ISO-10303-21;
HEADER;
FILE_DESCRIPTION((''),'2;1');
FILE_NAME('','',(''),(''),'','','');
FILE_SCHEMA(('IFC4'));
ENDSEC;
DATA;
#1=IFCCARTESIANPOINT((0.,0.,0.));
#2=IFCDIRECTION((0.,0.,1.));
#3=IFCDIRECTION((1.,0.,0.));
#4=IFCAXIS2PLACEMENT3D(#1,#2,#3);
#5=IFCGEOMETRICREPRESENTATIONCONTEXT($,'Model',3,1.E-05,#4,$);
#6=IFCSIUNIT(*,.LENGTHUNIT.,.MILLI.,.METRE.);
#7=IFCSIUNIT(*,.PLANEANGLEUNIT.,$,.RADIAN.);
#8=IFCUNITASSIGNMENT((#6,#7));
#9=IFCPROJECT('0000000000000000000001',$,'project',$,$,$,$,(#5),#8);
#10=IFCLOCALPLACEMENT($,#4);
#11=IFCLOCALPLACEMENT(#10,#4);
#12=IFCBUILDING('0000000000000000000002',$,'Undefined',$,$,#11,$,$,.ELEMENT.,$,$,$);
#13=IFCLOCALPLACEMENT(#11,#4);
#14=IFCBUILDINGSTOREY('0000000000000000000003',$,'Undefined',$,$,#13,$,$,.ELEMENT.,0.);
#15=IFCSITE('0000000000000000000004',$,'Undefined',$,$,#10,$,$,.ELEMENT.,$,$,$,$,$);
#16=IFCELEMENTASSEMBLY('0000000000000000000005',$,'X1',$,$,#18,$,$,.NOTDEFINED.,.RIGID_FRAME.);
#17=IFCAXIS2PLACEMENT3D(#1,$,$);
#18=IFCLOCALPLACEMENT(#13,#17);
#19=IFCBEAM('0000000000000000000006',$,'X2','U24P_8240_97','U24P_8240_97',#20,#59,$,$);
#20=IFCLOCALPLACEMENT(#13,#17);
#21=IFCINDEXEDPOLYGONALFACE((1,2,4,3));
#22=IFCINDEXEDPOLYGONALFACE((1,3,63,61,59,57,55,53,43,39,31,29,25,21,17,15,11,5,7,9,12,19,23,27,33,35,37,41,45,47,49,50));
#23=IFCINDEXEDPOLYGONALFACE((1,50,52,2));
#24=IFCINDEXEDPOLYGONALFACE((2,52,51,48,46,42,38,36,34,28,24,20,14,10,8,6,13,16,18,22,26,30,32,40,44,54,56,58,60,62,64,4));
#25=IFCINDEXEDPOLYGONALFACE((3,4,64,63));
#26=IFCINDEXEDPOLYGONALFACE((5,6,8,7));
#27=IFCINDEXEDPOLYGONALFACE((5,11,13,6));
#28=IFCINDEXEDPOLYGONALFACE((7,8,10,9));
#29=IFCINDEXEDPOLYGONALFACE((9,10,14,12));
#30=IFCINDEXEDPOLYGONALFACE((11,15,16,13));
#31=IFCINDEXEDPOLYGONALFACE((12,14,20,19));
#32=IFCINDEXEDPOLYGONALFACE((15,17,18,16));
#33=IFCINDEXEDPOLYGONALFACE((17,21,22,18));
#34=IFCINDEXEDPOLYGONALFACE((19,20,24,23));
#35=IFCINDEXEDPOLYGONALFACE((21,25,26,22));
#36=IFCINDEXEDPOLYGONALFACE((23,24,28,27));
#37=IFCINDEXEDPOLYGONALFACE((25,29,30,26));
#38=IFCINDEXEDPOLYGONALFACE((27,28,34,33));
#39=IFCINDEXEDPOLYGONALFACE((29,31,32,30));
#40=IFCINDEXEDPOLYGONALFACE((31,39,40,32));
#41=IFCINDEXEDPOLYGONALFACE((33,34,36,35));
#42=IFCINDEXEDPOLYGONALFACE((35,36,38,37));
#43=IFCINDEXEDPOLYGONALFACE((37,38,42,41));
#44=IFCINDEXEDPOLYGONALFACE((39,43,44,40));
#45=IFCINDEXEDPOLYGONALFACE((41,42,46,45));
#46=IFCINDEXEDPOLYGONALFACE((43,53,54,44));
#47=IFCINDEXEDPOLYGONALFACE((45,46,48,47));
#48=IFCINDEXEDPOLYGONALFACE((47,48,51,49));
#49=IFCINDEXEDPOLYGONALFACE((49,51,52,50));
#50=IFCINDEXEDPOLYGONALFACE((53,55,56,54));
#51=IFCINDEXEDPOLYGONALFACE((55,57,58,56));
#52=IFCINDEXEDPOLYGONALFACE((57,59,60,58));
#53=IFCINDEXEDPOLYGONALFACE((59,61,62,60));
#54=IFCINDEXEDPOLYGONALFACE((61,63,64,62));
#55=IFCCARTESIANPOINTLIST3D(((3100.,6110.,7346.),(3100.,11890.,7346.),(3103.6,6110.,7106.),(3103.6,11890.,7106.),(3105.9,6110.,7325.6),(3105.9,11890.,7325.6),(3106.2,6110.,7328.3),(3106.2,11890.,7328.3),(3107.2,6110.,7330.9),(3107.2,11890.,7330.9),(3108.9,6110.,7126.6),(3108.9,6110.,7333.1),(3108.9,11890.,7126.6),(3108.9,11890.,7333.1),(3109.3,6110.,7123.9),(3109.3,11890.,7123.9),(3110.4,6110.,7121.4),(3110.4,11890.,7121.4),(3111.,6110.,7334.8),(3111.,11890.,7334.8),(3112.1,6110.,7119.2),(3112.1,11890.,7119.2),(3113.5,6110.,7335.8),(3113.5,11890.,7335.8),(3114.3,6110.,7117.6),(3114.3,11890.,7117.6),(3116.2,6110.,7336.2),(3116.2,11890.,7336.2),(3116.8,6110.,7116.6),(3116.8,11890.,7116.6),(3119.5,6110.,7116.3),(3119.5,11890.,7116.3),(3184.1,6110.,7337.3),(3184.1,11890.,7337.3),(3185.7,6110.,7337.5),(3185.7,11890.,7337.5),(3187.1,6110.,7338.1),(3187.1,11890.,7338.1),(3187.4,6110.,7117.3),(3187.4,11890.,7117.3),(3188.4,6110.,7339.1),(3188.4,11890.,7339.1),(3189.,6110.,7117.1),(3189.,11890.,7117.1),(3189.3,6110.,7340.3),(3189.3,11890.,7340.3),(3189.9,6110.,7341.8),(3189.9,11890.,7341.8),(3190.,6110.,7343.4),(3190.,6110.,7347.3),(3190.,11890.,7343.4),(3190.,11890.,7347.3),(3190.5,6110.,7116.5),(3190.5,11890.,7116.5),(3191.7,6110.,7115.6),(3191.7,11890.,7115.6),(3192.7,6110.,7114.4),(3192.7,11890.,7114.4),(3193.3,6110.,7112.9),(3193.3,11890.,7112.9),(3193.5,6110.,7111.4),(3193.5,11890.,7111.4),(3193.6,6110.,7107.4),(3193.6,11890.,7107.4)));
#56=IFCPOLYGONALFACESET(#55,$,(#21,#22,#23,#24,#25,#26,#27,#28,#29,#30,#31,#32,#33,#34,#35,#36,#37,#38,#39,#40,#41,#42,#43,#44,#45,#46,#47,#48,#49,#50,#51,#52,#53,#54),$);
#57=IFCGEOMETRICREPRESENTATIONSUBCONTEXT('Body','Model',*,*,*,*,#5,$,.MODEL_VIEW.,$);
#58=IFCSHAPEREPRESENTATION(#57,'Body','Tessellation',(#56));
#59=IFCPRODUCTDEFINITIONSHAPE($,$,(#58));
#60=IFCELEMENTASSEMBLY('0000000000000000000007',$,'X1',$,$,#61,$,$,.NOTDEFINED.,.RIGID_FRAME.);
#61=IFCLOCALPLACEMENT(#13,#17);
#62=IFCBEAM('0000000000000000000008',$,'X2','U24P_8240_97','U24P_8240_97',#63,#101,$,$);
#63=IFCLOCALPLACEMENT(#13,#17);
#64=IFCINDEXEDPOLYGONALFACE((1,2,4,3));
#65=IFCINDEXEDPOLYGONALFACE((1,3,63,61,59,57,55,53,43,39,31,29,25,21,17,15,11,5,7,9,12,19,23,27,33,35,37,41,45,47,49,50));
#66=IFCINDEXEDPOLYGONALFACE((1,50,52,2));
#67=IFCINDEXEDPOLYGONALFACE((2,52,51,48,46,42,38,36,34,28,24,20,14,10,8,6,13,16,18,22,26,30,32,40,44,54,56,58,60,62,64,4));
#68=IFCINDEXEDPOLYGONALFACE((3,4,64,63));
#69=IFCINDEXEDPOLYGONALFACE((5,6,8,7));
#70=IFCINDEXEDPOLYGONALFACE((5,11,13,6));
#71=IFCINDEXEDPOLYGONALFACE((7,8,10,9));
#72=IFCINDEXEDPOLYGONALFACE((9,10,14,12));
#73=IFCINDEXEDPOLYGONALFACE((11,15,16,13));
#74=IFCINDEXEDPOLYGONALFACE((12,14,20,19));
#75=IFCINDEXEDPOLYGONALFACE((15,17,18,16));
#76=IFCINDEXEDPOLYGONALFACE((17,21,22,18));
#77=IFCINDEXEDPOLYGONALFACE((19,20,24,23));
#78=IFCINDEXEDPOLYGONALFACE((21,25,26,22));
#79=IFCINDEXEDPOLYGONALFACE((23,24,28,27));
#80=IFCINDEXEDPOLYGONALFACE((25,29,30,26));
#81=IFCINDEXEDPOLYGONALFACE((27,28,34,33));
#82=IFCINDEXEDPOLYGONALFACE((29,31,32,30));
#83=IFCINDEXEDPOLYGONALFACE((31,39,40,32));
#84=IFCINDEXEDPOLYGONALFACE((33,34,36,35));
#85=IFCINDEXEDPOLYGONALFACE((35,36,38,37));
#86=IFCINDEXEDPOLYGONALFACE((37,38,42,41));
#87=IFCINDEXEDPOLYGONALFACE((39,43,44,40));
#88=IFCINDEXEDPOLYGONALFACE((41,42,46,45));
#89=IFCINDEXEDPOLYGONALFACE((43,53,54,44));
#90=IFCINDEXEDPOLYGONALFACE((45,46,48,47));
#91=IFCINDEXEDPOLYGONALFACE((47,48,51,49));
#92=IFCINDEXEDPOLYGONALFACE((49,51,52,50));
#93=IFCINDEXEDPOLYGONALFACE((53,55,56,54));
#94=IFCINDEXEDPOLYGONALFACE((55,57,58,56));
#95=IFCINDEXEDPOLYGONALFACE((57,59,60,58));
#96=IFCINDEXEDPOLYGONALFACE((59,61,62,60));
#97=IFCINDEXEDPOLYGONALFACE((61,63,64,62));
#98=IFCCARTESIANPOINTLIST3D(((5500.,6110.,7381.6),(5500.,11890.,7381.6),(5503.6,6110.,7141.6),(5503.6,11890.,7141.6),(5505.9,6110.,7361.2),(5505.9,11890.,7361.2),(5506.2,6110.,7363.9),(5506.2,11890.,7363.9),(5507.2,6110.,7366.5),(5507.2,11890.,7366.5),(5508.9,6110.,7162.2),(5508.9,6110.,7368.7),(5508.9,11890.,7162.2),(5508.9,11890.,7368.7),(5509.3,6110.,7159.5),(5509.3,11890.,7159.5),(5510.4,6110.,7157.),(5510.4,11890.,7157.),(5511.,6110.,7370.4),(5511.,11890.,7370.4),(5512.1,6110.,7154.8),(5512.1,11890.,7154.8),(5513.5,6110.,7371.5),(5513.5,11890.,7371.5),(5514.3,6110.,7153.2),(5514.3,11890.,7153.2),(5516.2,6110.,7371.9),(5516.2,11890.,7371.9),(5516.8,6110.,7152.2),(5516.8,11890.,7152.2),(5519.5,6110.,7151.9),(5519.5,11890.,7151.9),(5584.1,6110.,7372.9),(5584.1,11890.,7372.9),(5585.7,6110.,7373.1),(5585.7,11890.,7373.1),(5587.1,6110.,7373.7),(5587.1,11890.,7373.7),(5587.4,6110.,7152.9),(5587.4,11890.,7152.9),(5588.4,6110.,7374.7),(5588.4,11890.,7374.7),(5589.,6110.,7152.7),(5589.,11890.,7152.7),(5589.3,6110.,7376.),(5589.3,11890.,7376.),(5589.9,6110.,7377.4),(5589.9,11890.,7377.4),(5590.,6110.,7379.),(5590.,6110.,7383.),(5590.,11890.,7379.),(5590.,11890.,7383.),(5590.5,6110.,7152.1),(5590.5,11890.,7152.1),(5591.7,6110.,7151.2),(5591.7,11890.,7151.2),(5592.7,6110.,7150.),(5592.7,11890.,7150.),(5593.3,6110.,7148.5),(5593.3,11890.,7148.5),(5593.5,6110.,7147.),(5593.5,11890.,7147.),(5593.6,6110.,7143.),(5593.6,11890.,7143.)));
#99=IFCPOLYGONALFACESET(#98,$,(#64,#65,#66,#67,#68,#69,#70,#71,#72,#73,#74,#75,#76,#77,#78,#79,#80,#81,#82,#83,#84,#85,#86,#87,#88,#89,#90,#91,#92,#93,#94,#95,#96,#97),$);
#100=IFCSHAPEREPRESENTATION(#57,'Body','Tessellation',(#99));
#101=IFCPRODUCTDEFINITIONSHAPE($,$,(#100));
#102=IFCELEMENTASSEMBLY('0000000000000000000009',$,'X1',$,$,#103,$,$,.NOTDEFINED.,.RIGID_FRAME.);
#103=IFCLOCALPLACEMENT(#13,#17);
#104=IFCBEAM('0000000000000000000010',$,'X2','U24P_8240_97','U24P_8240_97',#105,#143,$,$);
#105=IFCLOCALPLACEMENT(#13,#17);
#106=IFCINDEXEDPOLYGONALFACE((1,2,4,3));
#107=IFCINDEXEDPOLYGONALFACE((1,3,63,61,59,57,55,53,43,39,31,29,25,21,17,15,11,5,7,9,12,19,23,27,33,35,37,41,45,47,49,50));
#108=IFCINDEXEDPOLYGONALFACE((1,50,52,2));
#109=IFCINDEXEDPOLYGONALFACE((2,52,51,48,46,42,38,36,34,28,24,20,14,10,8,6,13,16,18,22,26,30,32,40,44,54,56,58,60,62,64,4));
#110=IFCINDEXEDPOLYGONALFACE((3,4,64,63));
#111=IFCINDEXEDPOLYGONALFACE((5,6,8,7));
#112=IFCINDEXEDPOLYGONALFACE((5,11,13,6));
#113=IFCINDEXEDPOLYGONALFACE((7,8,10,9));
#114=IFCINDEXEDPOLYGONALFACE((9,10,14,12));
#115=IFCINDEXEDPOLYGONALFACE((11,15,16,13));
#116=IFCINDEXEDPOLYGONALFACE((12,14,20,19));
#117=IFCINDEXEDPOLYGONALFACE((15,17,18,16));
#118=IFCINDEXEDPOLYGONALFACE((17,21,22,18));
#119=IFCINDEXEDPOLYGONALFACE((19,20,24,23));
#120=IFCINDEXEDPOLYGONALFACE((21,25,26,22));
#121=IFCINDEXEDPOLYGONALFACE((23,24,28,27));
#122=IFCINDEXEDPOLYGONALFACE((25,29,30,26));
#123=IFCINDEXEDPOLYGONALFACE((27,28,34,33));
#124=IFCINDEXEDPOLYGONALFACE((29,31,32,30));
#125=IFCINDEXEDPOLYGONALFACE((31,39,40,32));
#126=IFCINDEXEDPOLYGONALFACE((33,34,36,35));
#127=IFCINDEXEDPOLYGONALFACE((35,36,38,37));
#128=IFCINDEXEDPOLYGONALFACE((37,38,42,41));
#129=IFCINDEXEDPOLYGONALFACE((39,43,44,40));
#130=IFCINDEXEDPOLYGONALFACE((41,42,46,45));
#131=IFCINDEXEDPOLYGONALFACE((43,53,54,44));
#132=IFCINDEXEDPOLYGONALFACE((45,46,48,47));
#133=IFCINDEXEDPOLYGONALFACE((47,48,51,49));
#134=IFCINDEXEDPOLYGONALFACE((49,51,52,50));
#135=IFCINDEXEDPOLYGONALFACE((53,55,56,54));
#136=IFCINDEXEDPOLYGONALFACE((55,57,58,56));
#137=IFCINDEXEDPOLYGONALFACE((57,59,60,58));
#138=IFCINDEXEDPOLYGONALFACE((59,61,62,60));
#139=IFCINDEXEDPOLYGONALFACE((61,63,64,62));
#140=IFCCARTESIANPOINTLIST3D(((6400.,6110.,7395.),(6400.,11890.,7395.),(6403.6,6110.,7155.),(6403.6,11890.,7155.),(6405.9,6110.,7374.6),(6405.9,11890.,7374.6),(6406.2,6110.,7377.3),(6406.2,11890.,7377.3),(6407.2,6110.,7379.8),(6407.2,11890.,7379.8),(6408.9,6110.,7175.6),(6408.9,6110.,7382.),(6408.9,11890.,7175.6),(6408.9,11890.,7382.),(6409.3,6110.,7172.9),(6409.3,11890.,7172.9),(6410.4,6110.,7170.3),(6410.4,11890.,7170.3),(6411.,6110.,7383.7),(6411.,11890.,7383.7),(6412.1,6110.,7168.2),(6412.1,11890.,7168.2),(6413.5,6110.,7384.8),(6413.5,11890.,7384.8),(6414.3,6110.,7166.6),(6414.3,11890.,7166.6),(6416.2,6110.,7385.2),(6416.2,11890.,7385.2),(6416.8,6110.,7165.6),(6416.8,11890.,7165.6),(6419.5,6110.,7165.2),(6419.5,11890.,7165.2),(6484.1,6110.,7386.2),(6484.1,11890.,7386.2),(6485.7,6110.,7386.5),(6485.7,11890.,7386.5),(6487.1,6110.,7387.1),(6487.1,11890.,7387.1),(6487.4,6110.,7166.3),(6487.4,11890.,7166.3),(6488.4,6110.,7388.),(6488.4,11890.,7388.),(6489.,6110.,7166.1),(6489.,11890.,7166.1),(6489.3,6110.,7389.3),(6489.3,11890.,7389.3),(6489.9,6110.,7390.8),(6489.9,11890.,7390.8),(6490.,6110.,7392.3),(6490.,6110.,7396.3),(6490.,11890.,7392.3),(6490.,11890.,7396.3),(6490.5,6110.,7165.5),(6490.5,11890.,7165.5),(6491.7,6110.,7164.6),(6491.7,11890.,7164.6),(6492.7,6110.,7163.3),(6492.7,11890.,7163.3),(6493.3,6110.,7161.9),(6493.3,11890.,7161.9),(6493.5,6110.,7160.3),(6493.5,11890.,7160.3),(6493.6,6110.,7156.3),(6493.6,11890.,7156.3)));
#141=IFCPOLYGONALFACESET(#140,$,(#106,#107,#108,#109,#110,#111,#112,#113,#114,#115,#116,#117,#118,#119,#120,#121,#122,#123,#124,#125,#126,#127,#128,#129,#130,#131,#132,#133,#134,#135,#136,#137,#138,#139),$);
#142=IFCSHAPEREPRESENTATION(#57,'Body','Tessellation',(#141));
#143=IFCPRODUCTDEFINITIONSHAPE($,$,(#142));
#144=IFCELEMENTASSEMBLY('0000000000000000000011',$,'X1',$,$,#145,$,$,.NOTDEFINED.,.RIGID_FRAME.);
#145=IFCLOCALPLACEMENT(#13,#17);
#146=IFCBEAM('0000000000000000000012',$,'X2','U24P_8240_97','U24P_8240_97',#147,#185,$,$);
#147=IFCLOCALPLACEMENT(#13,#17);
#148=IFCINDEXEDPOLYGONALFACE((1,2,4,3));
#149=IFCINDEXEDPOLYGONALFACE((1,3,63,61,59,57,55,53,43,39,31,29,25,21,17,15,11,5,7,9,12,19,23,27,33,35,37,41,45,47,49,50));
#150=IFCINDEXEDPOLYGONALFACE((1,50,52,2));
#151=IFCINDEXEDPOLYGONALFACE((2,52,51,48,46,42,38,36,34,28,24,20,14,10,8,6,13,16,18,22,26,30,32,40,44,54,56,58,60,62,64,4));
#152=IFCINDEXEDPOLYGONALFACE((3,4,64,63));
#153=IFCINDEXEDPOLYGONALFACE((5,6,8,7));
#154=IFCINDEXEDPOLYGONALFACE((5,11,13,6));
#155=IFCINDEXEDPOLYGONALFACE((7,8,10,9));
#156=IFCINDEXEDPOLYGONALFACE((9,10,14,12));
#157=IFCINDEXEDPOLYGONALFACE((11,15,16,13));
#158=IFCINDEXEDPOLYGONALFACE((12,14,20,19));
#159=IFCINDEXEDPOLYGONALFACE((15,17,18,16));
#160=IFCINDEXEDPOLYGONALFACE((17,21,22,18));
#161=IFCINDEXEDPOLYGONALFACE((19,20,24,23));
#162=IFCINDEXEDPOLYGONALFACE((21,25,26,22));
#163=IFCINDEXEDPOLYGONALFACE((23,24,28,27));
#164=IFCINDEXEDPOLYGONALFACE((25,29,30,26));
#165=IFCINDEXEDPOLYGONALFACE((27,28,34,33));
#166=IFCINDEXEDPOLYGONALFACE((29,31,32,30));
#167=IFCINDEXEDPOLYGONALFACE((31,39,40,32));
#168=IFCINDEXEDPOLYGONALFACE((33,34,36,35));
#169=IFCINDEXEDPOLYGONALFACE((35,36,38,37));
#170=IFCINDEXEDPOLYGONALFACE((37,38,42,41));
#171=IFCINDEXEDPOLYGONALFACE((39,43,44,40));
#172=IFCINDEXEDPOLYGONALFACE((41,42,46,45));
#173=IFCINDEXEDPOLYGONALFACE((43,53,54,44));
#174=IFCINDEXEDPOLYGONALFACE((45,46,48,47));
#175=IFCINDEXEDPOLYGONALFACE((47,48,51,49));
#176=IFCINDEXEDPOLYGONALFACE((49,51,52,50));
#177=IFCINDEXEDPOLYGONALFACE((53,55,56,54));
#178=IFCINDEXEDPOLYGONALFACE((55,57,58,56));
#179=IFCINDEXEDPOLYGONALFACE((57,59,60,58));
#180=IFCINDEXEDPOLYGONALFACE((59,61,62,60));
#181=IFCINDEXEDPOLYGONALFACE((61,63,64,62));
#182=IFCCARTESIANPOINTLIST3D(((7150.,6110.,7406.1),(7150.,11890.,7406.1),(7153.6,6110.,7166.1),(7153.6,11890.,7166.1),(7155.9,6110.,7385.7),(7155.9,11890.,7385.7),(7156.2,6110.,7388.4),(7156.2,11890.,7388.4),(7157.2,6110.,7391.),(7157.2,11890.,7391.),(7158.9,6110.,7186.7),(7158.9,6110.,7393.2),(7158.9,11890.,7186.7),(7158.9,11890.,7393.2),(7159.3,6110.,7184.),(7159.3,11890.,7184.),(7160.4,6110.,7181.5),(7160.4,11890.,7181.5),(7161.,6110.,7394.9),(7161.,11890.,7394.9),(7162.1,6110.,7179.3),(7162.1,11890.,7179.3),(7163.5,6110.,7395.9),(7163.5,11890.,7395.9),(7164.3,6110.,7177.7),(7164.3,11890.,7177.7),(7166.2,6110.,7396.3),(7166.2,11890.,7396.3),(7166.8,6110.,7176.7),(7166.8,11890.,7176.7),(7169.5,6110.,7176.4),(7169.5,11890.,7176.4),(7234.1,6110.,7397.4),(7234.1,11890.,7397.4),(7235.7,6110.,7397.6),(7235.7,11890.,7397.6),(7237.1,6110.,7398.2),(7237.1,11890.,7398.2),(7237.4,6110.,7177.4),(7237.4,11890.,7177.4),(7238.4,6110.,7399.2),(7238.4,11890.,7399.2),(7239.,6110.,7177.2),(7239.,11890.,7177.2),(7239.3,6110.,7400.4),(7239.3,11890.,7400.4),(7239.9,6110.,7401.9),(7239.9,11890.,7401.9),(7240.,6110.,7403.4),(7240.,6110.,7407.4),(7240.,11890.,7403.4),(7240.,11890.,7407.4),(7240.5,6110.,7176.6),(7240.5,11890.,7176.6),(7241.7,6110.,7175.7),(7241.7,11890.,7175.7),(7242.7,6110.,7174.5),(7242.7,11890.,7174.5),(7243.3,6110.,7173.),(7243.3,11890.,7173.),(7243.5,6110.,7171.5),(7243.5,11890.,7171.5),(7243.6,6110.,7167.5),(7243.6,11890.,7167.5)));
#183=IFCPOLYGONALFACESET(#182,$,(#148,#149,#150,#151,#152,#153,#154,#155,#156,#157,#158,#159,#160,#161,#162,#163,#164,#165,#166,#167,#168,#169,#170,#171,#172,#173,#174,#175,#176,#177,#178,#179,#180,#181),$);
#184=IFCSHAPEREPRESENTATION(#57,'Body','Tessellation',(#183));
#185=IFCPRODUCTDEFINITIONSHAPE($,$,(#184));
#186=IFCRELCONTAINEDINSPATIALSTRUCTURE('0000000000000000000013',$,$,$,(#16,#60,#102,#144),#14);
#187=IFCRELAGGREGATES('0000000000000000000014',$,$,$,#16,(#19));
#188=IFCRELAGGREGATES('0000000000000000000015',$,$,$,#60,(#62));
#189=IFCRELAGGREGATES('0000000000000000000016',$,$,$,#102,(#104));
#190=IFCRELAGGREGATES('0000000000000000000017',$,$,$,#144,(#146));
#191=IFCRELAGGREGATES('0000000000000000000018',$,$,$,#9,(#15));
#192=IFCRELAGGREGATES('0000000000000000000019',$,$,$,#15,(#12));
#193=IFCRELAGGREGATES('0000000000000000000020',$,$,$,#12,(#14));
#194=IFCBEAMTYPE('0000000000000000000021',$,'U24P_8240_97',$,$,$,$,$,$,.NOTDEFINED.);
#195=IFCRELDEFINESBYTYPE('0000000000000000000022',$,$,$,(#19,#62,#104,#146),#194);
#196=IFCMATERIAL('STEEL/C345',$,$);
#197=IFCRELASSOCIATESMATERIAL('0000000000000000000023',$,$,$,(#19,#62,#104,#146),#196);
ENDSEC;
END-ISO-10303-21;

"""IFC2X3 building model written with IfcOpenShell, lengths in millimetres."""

from ifc_helpers import new_model, si_unit, frame, origin_with_axes, origin_2d_with_axis, place, context, subcontext, project, spatial, u_section, extrude, material, type_object, element, aggregate, save


model = new_model("IFC2X3")

# Units and contexts
model_context = context("Model", 3, precision=1e-05, world=origin_with_axes())
body_context = subcontext(model_context, "Body", "Model", "MODEL_VIEW")
ifc_project = project(units=[si_unit("LENGTHUNIT", "METRE", prefix="MILLI"), si_unit("PLANEANGLEUNIT", "RADIAN")], contexts=[model_context])

# Site, building, storey
site_placement = place(None, origin_with_axes())
site = spatial("IfcSite", under=ifc_project, at=site_placement, Name="Undefined", CompositionType="ELEMENT")
building_placement = place(site_placement, origin_with_axes())
building = spatial("IfcBuilding", under=site, at=building_placement, Name="Undefined", CompositionType="ELEMENT")
storey_placement = place(building_placement, origin_with_axes())
storey = spatial("IfcBuildingStorey", under=building, at=storey_placement, Name="Undefined", CompositionType="ELEMENT", Elevation=0.0)

# Element assemblies, beams
ifc_material_1 = material(Name="STEEL/C345")
beam_type_1 = type_object("IfcBeamType", Name="U24P_8240_97", PredefinedType="NOTDEFINED")
assembly_1_placement = place(storey_placement, origin_with_axes())
assembly_1 = element("IfcElementAssembly", 1, at=assembly_1_placement, inside=storey, Name="X1", AssemblyPlace="NOTDEFINED", PredefinedType="RIGID_FRAME")
beam_1_placement = place(assembly_1_placement, frame((3146.8, 11890.0, 7226.7), z_axis=(0.014998, 0.0, -0.999888), x_axis=(0.0, -1.0, 0.0)))
beam_1 = element("IfcBeam", 2, at=beam_1_placement, type_object=beam_type_1, material=ifc_material_1, Name="X2", Description="U24P_8240_97", ObjectType="U24P_8240_97", context=body_context, shape_type="SweptSolid", body=[
    extrude(u_section(Depth=240.0, FlangeWidth=90.0, WebThickness=5.6, FlangeThickness=10.0, FilletRadius=10.5, EdgeRadius=6.0, at=origin_2d_with_axis()), frame((5780.0, 0.0, 0.0), z_axis=(-1.0, 0.0, 0.0), x_axis=(0.0, -1.0, 0.0)), (0.0, 0.0, 1.0), 5780.0),
])
aggregate(assembly_1, [beam_1])
assembly_2_placement = place(storey_placement, origin_with_axes())
assembly_2 = element("IfcElementAssembly", 3, at=assembly_2_placement, inside=storey, Name="X1", AssemblyPlace="NOTDEFINED", PredefinedType="RIGID_FRAME")
beam_2_placement = place(assembly_2_placement, frame((5546.8, 11890.0, 7262.3), z_axis=(0.014998, 0.0, -0.999888), x_axis=(0.0, -1.0, 0.0)))
beam_2 = element("IfcBeam", 4, at=beam_2_placement, type_object=beam_type_1, material=ifc_material_1, Name="X2", Description="U24P_8240_97", ObjectType="U24P_8240_97", context=body_context, shape_type="SweptSolid", body=[
    extrude(u_section(Depth=240.0, FlangeWidth=90.0, WebThickness=5.6, FlangeThickness=10.0, FilletRadius=10.5, EdgeRadius=6.0, at=origin_2d_with_axis()), frame((5780.0, 0.0, 0.0), z_axis=(-1.0, 0.0, 0.0), x_axis=(0.0, -1.0, 0.0)), (0.0, 0.0, 1.0), 5780.0),
])
aggregate(assembly_2, [beam_2])
assembly_3_placement = place(storey_placement, origin_with_axes())
assembly_3 = element("IfcElementAssembly", 5, at=assembly_3_placement, inside=storey, Name="X1", AssemblyPlace="NOTDEFINED", PredefinedType="RIGID_FRAME")
beam_3_placement = place(assembly_3_placement, frame((6446.8, 11890.0, 7275.7), z_axis=(0.014998, 0.0, -0.999888), x_axis=(0.0, -1.0, 0.0)))
beam_3 = element("IfcBeam", 6, at=beam_3_placement, type_object=beam_type_1, material=ifc_material_1, Name="X2", Description="U24P_8240_97", ObjectType="U24P_8240_97", context=body_context, shape_type="SweptSolid", body=[
    extrude(u_section(Depth=240.0, FlangeWidth=90.0, WebThickness=5.6, FlangeThickness=10.0, FilletRadius=10.5, EdgeRadius=6.0, at=origin_2d_with_axis()), frame((5780.0, 0.0, 0.0), z_axis=(-1.0, 0.0, 0.0), x_axis=(0.0, -1.0, 0.0)), (0.0, 0.0, 1.0), 5780.0),
])
aggregate(assembly_3, [beam_3])
assembly_4_placement = place(storey_placement, origin_with_axes())
assembly_4 = element("IfcElementAssembly", 7, at=assembly_4_placement, inside=storey, Name="X1", AssemblyPlace="NOTDEFINED", PredefinedType="RIGID_FRAME")
beam_4_placement = place(assembly_4_placement, frame((7196.8, 11890.0, 7286.8), z_axis=(0.014998, 0.0, -0.999888), x_axis=(0.0, -1.0, 0.0)))
beam_4 = element("IfcBeam", 8, at=beam_4_placement, type_object=beam_type_1, material=ifc_material_1, Name="X2", Description="U24P_8240_97", ObjectType="U24P_8240_97", context=body_context, shape_type="SweptSolid", body=[
    extrude(u_section(Depth=240.0, FlangeWidth=90.0, WebThickness=5.6, FlangeThickness=10.0, FilletRadius=10.5, EdgeRadius=6.0, at=origin_2d_with_axis()), frame((5780.0, 0.0, 0.0), z_axis=(-1.0, 0.0, 0.0), x_axis=(0.0, -1.0, 0.0)), (0.0, 0.0, 1.0), 5780.0),
])
aggregate(assembly_4, [beam_4])

save(model, "model.ifc")
